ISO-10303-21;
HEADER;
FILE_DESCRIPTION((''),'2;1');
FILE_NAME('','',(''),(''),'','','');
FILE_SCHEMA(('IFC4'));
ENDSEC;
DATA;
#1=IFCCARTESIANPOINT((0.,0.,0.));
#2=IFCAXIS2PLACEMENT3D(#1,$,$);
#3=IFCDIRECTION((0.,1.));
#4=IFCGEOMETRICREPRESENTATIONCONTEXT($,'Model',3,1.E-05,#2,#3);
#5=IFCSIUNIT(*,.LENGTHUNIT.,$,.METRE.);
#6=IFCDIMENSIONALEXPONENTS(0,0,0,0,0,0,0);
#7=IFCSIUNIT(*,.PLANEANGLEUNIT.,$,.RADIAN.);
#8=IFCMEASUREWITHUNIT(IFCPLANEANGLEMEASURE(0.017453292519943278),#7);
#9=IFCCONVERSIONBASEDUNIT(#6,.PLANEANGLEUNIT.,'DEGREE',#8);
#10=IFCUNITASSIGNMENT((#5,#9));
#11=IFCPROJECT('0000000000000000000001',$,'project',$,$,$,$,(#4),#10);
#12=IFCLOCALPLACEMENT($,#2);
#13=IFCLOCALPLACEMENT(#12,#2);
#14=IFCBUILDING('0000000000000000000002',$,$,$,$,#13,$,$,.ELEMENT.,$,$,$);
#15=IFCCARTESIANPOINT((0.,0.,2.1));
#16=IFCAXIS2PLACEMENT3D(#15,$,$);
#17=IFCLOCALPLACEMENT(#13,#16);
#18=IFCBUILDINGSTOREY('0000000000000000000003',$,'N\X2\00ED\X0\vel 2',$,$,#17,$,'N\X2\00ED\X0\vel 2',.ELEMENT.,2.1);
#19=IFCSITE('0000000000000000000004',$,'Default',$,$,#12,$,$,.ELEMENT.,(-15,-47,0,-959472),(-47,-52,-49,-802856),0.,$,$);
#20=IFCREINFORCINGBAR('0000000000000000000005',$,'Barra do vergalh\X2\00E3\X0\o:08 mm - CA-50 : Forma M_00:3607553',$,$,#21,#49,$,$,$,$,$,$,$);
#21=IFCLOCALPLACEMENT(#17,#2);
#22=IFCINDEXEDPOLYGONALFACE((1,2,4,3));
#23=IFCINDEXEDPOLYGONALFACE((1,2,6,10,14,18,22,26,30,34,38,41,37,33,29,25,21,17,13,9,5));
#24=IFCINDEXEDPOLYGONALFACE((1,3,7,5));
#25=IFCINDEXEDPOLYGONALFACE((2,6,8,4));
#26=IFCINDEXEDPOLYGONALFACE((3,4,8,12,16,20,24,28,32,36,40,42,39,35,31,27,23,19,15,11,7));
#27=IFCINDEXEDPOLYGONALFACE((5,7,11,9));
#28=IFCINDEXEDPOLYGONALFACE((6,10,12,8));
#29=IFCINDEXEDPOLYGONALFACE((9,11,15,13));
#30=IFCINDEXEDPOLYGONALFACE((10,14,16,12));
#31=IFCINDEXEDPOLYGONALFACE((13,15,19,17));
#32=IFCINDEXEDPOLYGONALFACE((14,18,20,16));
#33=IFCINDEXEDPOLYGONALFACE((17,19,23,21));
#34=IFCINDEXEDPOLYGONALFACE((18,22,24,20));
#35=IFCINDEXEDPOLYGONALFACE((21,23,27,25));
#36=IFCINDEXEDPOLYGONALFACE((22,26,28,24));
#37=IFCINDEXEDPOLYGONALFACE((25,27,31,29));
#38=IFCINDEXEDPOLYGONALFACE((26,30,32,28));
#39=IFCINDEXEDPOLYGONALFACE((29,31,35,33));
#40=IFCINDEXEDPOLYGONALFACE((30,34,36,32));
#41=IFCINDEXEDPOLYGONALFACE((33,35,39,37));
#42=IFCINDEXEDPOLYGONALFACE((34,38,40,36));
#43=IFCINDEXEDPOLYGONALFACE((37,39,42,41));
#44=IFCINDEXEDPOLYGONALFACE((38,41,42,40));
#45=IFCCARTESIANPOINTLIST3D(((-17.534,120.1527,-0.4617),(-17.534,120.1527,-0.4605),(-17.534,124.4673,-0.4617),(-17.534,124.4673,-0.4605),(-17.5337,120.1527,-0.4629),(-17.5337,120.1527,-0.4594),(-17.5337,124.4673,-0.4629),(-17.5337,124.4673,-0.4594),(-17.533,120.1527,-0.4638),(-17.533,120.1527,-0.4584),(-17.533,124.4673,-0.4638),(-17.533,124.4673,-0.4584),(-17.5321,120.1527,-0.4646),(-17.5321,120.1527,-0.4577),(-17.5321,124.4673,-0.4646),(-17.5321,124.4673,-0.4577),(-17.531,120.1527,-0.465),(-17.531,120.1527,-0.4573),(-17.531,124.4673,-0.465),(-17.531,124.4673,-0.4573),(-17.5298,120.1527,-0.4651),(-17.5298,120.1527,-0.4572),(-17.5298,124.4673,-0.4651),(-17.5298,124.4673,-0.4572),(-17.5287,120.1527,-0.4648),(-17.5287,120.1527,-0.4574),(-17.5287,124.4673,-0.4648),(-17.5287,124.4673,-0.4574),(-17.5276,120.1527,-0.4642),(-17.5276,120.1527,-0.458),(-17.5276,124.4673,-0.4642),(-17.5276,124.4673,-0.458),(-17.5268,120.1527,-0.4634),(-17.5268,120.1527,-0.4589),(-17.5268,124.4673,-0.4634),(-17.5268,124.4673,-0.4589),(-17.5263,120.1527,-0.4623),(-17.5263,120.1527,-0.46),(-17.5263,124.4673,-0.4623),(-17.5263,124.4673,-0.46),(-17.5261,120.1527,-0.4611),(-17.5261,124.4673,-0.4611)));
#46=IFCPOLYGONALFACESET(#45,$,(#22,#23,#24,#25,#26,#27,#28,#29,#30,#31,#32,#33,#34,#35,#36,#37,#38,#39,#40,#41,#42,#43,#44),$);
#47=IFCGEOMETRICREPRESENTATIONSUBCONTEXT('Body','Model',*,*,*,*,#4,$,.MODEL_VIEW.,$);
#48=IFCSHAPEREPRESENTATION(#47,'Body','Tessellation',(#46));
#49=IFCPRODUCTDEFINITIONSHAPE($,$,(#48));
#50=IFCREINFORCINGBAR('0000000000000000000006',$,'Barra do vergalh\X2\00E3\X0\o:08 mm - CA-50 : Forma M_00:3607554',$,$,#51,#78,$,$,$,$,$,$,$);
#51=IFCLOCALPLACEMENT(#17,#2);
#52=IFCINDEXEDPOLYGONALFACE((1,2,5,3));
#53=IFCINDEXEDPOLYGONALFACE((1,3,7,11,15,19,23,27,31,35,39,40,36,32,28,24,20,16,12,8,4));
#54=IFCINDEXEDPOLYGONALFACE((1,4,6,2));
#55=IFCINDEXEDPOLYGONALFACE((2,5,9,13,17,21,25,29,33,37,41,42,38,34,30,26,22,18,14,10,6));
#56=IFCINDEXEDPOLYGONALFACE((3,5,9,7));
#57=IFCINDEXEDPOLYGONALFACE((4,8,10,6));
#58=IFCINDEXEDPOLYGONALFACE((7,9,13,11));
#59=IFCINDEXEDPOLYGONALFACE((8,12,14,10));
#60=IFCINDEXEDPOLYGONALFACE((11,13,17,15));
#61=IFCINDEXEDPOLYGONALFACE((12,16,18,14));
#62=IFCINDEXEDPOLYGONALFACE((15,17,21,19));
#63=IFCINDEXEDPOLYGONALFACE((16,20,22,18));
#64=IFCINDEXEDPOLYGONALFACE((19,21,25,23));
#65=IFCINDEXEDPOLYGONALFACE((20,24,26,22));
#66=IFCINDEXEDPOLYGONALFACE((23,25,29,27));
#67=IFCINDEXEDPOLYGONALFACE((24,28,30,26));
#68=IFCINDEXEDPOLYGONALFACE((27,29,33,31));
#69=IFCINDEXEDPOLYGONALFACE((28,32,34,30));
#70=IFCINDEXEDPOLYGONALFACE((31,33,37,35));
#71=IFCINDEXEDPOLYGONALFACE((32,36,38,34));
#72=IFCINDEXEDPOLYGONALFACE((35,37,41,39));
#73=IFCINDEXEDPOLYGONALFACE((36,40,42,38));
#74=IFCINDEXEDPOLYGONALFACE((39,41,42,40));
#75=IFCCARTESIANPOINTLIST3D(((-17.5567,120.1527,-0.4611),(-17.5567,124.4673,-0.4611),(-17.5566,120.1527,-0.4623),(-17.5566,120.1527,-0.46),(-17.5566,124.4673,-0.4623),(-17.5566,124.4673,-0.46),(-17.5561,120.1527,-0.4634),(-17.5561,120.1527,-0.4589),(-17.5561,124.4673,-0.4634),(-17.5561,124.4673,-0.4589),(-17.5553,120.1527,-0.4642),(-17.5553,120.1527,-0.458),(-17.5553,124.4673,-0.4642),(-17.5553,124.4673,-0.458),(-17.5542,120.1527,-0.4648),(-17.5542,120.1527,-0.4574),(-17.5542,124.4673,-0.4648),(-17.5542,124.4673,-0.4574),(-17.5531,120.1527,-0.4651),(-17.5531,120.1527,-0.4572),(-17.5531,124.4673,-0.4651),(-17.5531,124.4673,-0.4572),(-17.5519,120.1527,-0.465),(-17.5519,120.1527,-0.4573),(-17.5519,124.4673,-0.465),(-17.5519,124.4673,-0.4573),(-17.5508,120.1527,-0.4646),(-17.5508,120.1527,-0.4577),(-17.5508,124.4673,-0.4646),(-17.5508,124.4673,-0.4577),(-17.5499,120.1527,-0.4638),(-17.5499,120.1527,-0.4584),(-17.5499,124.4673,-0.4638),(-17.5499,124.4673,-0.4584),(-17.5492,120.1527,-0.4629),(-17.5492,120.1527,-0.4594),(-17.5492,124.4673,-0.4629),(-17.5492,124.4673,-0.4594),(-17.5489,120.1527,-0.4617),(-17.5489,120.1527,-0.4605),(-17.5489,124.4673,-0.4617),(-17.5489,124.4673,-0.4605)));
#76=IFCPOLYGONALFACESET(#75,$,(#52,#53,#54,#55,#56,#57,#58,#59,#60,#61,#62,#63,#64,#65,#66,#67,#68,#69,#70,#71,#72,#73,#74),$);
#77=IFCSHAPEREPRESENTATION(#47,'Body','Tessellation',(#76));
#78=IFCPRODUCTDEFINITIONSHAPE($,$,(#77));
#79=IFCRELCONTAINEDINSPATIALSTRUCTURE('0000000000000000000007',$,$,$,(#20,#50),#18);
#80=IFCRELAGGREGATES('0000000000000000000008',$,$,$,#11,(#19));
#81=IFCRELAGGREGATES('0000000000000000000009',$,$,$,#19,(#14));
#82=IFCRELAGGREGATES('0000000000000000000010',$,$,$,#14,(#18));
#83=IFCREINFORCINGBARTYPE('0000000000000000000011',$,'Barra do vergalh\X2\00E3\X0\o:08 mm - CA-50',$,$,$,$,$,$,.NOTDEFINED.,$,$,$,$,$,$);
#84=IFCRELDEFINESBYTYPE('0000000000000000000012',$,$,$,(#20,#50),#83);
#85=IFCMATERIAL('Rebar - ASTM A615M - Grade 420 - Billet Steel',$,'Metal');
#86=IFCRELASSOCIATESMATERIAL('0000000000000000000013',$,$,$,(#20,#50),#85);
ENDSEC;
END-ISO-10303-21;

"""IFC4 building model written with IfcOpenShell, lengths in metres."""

from ifc_helpers import new_model, entity, si_unit, converted_unit, direction, frame, origin, place, context, subcontext, project, spatial, material, type_object, element, save


model = new_model("IFC4")

# Units and contexts
model_context = context("Model", 3, precision=1e-05, world=origin(), true_north=direction((0.0, 1.0)))
body_context = subcontext(model_context, "Body", "Model", "MODEL_VIEW")
ifc_project = project(units=[si_unit("LENGTHUNIT", "METRE"), converted_unit("PLANEANGLEUNIT", "DEGREE", entity("IfcPlaneAngleMeasure", 0.017453292519943278), si_unit("PLANEANGLEUNIT", "RADIAN"), dimensions=[0, 0, 0, 0, 0, 0, 0])], contexts=[model_context])

# Site, building, storey
site_placement = place(None, origin())
site = spatial("IfcSite", under=ifc_project, at=site_placement, Name="Default", CompositionType="ELEMENT", RefLatitude=(-15, -47, 0, -959472), RefLongitude=(-47, -52, -49, -802856), RefElevation=0.0)
building_placement = place(site_placement, origin())
building = spatial("IfcBuilding", under=site, at=building_placement, CompositionType="ELEMENT")
storey_placement = place(building_placement, frame((0.0, 0.0, 2.1)))
storey = spatial("IfcBuildingStorey", under=building, at=storey_placement, Name="Nível 2", LongName="Nível 2", CompositionType="ELEMENT", Elevation=2.1)

# Reinforcing bars
ifc_material = material(Name="Rebar - ASTM A615M - Grade 420 - Billet Steel", Category="Metal")
reinforcing_bar_type_1 = type_object("IfcReinforcingBarType", Name="Barra do vergalhão:08 mm - CA-50", PredefinedType="NOTDEFINED")
reinforcing_bar_1_placement = place(storey_placement, origin())
element("IfcReinforcingBar", 1, at=reinforcing_bar_1_placement, inside=storey, type_object=reinforcing_bar_type_1, material=ifc_material, Name="Barra do vergalhão:08 mm - CA-50 : Forma M_00:3607553", context=body_context, shape_type="AdvancedSweptSolid", body=[
    entity("IfcSweptDiskSolid", entity("IfcIndexedPolyCurve", entity("IfcCartesianPointList3D", [[17.5301, -124.4673, 0.4611], [17.5301, -120.1527, 0.4611]]), None, False), 0.004, None, 0.0, 1.0),
])
reinforcing_bar_2_placement = place(storey_placement, origin())
element("IfcReinforcingBar", 2, at=reinforcing_bar_2_placement, inside=storey, type_object=reinforcing_bar_type_1, material=ifc_material, Name="Barra do vergalhão:08 mm - CA-50 : Forma M_00:3607554", context=body_context, shape_type="AdvancedSweptSolid", body=[
    entity("IfcSweptDiskSolid", entity("IfcIndexedPolyCurve", entity("IfcCartesianPointList3D", [[17.5528, -120.1527, 0.4611], [17.5528, -124.4673, 0.4611]]), None, False), 0.004, None, 0.0, 1.0),
])

save(model, "model.ifc")
